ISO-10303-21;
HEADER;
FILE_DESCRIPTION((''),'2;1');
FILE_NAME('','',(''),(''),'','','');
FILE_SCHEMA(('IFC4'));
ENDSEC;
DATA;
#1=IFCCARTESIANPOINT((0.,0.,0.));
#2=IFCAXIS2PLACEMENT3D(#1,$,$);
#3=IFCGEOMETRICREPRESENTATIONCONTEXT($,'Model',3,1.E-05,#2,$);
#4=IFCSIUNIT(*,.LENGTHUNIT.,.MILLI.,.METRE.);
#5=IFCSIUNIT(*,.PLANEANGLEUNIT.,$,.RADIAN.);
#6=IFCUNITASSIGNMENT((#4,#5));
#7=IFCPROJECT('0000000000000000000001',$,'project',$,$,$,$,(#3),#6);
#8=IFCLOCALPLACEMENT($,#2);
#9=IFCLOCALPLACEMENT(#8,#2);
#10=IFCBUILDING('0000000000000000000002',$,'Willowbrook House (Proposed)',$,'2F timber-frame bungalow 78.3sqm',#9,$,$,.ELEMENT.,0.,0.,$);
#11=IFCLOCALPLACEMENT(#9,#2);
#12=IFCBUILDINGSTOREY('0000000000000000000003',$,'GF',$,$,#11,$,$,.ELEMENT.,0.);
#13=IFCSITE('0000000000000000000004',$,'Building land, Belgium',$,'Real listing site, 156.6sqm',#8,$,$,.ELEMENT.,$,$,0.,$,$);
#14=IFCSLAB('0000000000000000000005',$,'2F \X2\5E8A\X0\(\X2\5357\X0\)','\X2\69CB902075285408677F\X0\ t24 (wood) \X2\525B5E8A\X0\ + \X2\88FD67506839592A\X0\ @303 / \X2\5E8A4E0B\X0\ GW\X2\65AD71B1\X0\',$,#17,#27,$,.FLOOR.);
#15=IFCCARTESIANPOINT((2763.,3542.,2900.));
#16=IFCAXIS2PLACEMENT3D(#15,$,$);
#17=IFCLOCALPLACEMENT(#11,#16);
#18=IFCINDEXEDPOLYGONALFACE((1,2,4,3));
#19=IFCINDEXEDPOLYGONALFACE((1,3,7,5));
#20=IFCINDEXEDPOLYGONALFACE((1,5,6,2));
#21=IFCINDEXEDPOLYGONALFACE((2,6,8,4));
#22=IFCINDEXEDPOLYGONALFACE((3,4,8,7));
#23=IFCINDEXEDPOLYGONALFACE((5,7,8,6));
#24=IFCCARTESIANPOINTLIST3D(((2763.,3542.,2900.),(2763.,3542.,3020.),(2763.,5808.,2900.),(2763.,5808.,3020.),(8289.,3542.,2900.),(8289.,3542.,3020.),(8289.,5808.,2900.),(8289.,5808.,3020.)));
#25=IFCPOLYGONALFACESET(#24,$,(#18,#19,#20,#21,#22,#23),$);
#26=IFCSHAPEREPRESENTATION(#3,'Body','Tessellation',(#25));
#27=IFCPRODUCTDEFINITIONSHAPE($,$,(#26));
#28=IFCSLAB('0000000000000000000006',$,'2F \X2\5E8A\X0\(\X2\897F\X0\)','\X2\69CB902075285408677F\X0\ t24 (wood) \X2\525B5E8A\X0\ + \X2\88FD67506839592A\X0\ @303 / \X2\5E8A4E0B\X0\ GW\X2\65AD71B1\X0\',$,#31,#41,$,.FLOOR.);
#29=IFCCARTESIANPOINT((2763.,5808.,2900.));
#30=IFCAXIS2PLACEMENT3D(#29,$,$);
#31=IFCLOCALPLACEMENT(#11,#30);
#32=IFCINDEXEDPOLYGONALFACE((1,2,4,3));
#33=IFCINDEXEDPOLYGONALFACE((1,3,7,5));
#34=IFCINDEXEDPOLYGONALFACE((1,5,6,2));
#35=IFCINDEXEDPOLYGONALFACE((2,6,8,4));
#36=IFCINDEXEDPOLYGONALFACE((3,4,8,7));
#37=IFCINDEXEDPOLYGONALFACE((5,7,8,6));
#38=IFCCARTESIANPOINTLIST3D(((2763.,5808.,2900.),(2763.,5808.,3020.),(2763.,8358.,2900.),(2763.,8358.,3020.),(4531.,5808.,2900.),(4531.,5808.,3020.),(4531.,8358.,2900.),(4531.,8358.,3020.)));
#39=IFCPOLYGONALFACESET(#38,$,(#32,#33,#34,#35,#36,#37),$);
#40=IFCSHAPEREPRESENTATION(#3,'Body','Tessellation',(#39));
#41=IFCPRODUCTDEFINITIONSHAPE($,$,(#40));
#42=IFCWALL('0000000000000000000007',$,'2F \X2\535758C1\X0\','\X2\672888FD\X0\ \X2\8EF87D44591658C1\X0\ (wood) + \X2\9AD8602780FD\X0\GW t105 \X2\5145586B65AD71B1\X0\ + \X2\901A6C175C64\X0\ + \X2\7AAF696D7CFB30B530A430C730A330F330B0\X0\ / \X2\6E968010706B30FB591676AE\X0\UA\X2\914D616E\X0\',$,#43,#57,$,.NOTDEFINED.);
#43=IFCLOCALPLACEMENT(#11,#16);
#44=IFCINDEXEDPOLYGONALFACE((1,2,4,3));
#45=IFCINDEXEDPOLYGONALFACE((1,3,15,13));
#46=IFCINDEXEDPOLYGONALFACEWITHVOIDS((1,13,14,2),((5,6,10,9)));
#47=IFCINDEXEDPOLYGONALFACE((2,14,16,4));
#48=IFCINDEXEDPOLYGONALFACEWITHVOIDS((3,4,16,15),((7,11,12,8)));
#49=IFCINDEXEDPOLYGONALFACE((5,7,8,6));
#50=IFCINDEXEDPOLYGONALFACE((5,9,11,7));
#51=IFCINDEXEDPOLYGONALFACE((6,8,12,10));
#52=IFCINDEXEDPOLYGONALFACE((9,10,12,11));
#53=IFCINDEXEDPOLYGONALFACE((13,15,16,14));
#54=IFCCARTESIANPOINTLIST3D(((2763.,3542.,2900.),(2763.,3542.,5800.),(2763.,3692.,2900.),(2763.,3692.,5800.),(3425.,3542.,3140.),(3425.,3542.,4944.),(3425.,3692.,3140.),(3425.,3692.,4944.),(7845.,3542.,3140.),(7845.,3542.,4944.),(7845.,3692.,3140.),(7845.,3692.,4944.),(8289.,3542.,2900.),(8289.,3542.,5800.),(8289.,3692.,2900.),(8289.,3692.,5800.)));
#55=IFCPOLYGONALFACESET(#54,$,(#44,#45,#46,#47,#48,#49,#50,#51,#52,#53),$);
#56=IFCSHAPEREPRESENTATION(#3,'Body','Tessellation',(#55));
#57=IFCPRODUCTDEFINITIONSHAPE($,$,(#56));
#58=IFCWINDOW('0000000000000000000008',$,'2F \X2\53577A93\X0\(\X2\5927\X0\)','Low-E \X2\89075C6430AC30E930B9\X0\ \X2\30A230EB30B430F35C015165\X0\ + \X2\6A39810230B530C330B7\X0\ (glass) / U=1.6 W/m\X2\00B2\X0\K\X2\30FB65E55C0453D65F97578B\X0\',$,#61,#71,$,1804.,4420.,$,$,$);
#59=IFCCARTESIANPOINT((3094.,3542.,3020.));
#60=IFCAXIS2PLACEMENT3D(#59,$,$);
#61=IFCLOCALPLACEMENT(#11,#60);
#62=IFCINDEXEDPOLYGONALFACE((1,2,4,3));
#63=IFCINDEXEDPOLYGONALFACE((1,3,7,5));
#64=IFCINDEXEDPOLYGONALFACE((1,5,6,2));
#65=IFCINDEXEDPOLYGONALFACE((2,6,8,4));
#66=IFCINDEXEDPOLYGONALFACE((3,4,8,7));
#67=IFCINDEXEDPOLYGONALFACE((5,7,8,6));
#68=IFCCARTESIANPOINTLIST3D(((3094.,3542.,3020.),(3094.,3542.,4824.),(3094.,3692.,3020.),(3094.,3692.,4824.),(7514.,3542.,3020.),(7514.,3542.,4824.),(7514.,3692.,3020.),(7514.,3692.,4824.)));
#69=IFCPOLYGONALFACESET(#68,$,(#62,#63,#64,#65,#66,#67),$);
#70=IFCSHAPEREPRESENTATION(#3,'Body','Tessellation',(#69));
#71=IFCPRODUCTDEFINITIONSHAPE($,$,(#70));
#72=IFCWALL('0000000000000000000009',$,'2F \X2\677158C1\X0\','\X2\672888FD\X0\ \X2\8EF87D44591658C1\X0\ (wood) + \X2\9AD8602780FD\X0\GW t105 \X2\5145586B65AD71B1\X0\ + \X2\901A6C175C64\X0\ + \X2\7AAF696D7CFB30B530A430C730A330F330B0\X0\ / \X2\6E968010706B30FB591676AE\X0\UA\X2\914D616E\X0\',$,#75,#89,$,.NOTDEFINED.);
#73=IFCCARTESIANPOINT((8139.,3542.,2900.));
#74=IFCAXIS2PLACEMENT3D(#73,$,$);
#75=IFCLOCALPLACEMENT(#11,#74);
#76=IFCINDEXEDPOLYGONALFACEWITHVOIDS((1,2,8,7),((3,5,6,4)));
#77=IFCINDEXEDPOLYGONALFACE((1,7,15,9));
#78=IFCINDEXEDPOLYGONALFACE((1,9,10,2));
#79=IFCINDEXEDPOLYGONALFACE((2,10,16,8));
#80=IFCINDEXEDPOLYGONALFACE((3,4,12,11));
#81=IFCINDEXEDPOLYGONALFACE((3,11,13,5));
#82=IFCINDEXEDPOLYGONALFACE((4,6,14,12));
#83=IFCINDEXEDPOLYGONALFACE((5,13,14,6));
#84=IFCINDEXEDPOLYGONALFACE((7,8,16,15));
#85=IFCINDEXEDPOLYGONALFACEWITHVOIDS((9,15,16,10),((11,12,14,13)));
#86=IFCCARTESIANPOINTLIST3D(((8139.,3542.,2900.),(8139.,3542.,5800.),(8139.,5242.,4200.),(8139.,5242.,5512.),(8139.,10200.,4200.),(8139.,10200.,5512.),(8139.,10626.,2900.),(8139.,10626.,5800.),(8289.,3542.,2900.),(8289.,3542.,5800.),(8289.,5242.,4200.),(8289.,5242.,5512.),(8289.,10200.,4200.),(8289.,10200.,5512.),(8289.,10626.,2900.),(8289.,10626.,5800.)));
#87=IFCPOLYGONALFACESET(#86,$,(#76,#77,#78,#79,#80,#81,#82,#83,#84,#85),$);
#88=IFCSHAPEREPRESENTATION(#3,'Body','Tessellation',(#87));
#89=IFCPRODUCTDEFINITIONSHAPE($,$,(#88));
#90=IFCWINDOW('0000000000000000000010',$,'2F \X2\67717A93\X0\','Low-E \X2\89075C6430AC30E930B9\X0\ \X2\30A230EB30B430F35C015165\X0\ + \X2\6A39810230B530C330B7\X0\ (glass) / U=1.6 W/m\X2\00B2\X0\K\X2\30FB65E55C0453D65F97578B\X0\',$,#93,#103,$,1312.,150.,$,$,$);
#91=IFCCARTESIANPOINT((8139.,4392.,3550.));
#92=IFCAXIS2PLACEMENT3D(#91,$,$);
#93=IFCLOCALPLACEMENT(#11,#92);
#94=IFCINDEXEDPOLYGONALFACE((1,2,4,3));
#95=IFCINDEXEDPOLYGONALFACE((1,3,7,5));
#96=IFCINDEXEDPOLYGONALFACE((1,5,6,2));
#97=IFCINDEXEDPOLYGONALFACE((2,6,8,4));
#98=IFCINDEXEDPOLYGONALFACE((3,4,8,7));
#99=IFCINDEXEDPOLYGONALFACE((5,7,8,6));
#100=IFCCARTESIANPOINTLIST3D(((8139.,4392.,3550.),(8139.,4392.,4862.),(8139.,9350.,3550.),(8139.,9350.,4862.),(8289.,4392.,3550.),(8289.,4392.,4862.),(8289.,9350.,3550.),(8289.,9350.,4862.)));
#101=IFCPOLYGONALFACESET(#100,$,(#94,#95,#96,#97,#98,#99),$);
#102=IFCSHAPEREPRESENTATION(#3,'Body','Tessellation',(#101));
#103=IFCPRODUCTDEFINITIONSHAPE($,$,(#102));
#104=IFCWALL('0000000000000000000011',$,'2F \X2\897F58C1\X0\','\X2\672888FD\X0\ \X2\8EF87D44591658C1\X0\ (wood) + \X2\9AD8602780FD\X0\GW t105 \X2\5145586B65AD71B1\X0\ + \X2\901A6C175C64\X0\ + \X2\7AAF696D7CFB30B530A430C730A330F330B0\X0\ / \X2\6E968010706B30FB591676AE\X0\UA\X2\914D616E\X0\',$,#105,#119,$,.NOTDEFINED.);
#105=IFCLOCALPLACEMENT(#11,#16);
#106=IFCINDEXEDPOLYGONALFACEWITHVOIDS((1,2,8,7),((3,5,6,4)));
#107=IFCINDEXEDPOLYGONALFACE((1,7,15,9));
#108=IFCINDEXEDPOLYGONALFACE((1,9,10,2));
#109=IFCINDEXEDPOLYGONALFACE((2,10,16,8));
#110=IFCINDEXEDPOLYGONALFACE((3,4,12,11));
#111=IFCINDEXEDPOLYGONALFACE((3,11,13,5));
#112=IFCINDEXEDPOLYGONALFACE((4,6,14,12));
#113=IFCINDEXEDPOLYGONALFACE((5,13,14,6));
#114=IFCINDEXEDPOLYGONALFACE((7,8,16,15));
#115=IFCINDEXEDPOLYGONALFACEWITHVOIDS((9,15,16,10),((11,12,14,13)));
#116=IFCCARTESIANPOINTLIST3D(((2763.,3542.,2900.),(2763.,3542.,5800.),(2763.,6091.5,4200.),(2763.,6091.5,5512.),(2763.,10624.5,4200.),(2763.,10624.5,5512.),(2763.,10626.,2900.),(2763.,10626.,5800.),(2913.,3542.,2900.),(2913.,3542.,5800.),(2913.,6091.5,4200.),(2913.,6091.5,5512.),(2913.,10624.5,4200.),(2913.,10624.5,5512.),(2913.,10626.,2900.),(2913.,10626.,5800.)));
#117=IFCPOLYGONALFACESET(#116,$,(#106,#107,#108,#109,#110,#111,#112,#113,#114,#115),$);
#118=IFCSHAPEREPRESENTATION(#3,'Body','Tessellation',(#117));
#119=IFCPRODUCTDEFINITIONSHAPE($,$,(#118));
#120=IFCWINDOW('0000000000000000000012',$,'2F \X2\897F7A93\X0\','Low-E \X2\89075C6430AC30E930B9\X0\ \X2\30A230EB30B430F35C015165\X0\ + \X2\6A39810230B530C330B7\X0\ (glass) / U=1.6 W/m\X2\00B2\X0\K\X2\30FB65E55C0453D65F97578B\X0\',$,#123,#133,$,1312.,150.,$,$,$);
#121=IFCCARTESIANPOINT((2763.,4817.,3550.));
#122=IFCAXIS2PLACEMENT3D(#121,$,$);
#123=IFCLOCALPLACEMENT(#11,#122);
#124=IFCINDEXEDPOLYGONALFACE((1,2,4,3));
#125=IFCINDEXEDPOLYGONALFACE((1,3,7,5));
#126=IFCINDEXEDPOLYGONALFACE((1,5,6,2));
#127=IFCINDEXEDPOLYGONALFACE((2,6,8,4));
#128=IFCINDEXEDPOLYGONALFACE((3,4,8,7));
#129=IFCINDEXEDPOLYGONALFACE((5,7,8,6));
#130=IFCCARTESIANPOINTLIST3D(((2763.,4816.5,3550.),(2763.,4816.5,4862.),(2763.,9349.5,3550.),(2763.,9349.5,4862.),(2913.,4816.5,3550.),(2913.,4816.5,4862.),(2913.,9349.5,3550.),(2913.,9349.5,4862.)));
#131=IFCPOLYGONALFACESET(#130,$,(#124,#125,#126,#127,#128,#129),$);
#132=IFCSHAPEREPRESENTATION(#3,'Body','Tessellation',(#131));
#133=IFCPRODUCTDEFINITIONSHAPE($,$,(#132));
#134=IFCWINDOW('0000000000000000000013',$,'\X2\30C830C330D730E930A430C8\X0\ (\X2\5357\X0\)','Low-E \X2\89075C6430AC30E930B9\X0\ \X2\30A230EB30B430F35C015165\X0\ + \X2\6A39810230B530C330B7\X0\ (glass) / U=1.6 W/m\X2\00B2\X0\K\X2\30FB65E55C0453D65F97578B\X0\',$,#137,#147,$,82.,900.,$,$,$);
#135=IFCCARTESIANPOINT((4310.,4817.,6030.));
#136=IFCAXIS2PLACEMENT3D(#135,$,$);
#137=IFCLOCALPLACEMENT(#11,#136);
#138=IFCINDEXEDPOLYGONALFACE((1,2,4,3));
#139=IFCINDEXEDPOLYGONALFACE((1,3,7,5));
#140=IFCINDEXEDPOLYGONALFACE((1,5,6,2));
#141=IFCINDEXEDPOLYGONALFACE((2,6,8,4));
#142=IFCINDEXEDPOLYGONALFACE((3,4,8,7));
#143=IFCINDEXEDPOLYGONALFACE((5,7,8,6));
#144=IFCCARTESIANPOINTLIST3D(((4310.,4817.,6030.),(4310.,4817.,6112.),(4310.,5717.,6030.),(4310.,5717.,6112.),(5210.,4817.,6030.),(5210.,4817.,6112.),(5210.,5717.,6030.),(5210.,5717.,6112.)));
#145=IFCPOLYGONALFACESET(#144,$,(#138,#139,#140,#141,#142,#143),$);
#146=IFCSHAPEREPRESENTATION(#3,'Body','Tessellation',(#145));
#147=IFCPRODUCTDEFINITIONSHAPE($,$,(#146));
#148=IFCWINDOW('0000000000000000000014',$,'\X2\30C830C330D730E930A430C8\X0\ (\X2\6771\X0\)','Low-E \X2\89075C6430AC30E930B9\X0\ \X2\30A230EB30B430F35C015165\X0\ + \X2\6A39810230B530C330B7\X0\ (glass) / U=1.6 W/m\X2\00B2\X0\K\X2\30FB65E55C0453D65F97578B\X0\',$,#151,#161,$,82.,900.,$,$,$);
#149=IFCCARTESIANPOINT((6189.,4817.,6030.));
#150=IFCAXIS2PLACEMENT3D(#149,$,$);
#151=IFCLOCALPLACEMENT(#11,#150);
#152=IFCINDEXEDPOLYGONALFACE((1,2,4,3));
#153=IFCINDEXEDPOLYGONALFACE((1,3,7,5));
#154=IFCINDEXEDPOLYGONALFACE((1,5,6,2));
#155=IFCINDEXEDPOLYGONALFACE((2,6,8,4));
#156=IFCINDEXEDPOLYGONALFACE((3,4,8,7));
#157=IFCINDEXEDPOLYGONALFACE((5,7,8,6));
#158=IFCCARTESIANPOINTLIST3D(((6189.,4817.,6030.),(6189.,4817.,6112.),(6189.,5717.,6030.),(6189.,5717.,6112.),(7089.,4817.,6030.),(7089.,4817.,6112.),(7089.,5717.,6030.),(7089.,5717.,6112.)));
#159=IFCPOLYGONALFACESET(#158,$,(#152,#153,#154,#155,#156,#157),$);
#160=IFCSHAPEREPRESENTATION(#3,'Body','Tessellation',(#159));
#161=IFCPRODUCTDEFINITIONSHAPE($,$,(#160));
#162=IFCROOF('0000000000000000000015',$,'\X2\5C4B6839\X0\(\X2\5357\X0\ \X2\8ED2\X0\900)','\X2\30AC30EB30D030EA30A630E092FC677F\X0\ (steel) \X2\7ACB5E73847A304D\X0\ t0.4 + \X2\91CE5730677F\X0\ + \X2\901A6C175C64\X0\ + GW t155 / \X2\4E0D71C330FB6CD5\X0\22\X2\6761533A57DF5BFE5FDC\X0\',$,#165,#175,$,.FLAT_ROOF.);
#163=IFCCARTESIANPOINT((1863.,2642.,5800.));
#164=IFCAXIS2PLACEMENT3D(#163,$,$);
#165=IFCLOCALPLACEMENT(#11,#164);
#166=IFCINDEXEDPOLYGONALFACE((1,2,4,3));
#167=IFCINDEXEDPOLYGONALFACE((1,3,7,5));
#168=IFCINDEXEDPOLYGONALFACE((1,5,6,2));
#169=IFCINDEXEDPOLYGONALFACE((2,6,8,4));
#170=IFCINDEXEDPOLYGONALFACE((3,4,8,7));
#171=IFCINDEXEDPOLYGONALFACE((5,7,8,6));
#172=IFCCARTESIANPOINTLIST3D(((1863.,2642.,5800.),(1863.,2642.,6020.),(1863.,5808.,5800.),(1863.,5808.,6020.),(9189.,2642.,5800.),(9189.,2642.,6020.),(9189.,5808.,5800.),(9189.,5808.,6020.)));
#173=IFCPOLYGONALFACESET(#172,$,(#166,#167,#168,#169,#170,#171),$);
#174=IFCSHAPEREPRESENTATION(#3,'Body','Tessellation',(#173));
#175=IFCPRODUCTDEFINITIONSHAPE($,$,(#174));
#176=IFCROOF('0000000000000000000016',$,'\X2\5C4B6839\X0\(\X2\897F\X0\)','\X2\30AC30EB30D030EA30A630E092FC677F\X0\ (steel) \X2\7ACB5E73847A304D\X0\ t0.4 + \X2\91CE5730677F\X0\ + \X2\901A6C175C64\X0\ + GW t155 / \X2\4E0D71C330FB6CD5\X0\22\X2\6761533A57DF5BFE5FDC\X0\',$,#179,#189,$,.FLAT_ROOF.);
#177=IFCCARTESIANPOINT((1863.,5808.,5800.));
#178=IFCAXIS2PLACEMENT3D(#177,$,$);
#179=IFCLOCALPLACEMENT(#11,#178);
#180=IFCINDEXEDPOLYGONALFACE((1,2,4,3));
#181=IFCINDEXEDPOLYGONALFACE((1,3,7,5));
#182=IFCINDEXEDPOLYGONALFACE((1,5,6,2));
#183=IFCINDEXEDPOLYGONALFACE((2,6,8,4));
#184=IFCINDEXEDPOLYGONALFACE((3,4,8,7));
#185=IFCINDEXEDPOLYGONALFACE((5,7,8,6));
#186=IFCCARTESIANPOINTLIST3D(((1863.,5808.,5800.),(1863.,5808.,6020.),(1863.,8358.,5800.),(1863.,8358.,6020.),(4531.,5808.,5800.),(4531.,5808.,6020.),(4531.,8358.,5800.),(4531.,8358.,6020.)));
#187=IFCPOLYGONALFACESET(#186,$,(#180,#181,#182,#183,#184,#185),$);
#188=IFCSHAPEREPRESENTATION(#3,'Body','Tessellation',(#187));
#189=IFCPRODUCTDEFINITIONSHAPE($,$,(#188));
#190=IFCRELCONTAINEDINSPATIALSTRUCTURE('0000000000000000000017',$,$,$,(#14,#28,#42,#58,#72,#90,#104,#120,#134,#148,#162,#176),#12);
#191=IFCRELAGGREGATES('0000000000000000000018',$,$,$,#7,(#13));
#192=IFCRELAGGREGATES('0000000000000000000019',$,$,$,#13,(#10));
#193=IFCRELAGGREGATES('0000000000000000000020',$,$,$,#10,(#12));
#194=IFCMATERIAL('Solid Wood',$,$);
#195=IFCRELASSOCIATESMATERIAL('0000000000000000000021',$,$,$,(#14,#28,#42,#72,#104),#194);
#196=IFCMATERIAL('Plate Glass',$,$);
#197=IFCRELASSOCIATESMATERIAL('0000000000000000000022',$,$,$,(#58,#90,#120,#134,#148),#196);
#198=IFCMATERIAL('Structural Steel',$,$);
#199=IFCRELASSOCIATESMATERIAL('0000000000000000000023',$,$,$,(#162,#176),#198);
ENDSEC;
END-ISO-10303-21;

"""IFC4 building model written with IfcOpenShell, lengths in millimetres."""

from ifc_helpers import new_model, si_unit, frame, frame_2d, origin, place, context, project, spatial, rectangle, extrude, material, element, fill, save


model = new_model("IFC4")

# Units and contexts
model_context = context("Model", 3, precision=1e-05, world=origin())
ifc_project = project(units=[si_unit("LENGTHUNIT", "METRE", prefix="MILLI"), si_unit("PLANEANGLEUNIT", "RADIAN")], contexts=[model_context])

# Site, building, storey
site_placement = place(None, origin())
site = spatial("IfcSite", under=ifc_project, at=site_placement, Name="Building land, Belgium", ObjectType="Real listing site, 156.6sqm", CompositionType="ELEMENT", RefElevation=0.0)
building_placement = place(site_placement, origin())
building = spatial("IfcBuilding", under=site, at=building_placement, Name="Willowbrook House (Proposed)", ObjectType="2F timber-frame bungalow 78.3sqm", CompositionType="ELEMENT", ElevationOfRefHeight=0.0, ElevationOfTerrain=0.0)
storey_placement = place(building_placement, origin())
storey = spatial("IfcBuildingStorey", under=building, at=storey_placement, Name="GF", CompositionType="ELEMENT", Elevation=0.0)

# Slabs
ifc_material_1 = material(Name="Solid Wood")
slab_1_placement = place(storey_placement, frame((2763.0, 3542.0, 2900.0)))
element("IfcSlab", 1, at=slab_1_placement, inside=storey, material=ifc_material_1, Name="2F 床(南)", Description="構造用合板 t24 (wood) 剛床 + 製材根太 @303 / 床下 GW断熱", PredefinedType="FLOOR", context=model_context, shape_type="SweptSolid", body=[
    extrude(rectangle(XDim=5526.0, YDim=2266.0, at=frame_2d((2763.0, 1133.0))), frame((2763.0, 3542.0, 2900.0)), (0.0, 0.0, 1.0), 120.0),
])
slab_2_placement = place(storey_placement, frame((2763.0, 5808.0, 2900.0)))
element("IfcSlab", 2, at=slab_2_placement, inside=storey, material=ifc_material_1, Name="2F 床(西)", Description="構造用合板 t24 (wood) 剛床 + 製材根太 @303 / 床下 GW断熱", PredefinedType="FLOOR", context=model_context, shape_type="SweptSolid", body=[
    extrude(rectangle(XDim=1768.0, YDim=2550.0, at=frame_2d((884.0, 1275.0))), frame((2763.0, 5808.0, 2900.0)), (0.0, 0.0, 1.0), 120.0),
])

# Walls, openings, windows
wall_1_placement = place(storey_placement, frame((2763.0, 3542.0, 2900.0)))
wall_1 = element("IfcWall", 3, at=wall_1_placement, inside=storey, material=ifc_material_1, Name="2F 南壁", Description="木製 軸組外壁 (wood) + 高性能GW t105 充填断熱 + 通気層 + 窯業系サイディング / 準耐火・外皮UA配慮", PredefinedType="NOTDEFINED", context=model_context, shape_type="SweptSolid", body=[
    extrude(rectangle(XDim=5526.0, YDim=150.0, at=frame_2d((2763.0, 75.0))), frame((2763.0, 3542.0, 2900.0)), (0.0, 0.0, 1.0), 2900.0),
])
opening_1_placement = place(storey_placement, frame((3094.0, 3542.0, 3020.0)))
opening_1 = element("IfcOpeningElement", 4, at=opening_1_placement, cuts=wall_1, PredefinedType="NOTDEFINED", context=model_context, shape_type="SweptSolid", body=[
    extrude(rectangle(XDim=4420.0, YDim=150.0, at=frame_2d((2210.0, 75.0))), frame((3094.0, 3542.0, 3020.0)), (0.0, 0.0, 1.0), 1804.0),
])
ifc_material_2 = material(Name="Plate Glass")
window_1_placement = place(storey_placement, frame((3094.0, 3542.0, 3020.0)))
window_1 = element("IfcWindow", 5, at=window_1_placement, inside=storey, material=ifc_material_2, Name="2F 南窓(大)", Description="Low-E 複層ガラス アルゴン封入 + 樹脂サッシ (glass) / U=1.6 W/m²K・日射取得型", OverallHeight=1804.0, OverallWidth=4420.0, context=model_context, shape_type="SweptSolid", body=[
    extrude(rectangle(XDim=4420.0, YDim=150.0, at=frame_2d((2210.0, 75.0))), frame((3094.0, 3542.0, 3020.0)), (0.0, 0.0, 1.0), 1804.0),
])
fill(opening_1, window_1)
wall_2_placement = place(storey_placement, frame((8139.0, 3542.0, 2900.0)))
wall_2 = element("IfcWall", 6, at=wall_2_placement, inside=storey, material=ifc_material_1, Name="2F 東壁", Description="木製 軸組外壁 (wood) + 高性能GW t105 充填断熱 + 通気層 + 窯業系サイディング / 準耐火・外皮UA配慮", PredefinedType="NOTDEFINED", context=model_context, shape_type="SweptSolid", body=[
    extrude(rectangle(XDim=150.0, YDim=7084.0, at=frame_2d((75.0, 3542.0))), frame((8139.0, 3542.0, 2900.0)), (0.0, 0.0, 1.0), 2900.0),
])
opening_2_placement = place(storey_placement, frame((8139.0, 4392.0, 3550.0)))
opening_2 = element("IfcOpeningElement", 7, at=opening_2_placement, cuts=wall_2, PredefinedType="NOTDEFINED", context=model_context, shape_type="SweptSolid", body=[
    extrude(rectangle(XDim=150.0, YDim=4958.0, at=frame_2d((75.0, 2479.0))), frame((8139.0, 4392.0, 3550.0)), (0.0, 0.0, 1.0), 1312.0),
])
window_2_placement = place(storey_placement, frame((8139.0, 4392.0, 3550.0)))
window_2 = element("IfcWindow", 8, at=window_2_placement, inside=storey, material=ifc_material_2, Name="2F 東窓", Description="Low-E 複層ガラス アルゴン封入 + 樹脂サッシ (glass) / U=1.6 W/m²K・日射取得型", OverallHeight=1312.0, OverallWidth=150.0, context=model_context, shape_type="SweptSolid", body=[
    extrude(rectangle(XDim=150.0, YDim=4958.0, at=frame_2d((75.0, 2479.0))), frame((8139.0, 4392.0, 3550.0)), (0.0, 0.0, 1.0), 1312.0),
])
fill(opening_2, window_2)
wall_3_placement = place(storey_placement, frame((2763.0, 3542.0, 2900.0)))
wall_3 = element("IfcWall", 9, at=wall_3_placement, inside=storey, material=ifc_material_1, Name="2F 西壁", Description="木製 軸組外壁 (wood) + 高性能GW t105 充填断熱 + 通気層 + 窯業系サイディング / 準耐火・外皮UA配慮", PredefinedType="NOTDEFINED", context=model_context, shape_type="SweptSolid", body=[
    extrude(rectangle(XDim=150.0, YDim=7084.0, at=frame_2d((75.0, 3542.0))), frame((2763.0, 3542.0, 2900.0)), (0.0, 0.0, 1.0), 2900.0),
])
opening_3_placement = place(storey_placement, frame((2763.0, 4817.0, 3550.0)))
opening_3 = element("IfcOpeningElement", 10, at=opening_3_placement, cuts=wall_3, PredefinedType="NOTDEFINED", context=model_context, shape_type="SweptSolid", body=[
    extrude(rectangle(XDim=150.0, YDim=4533.0, at=frame_2d((75.0, 2266.0))), frame((2763.0, 4817.0, 3550.0)), (0.0, 0.0, 1.0), 1312.0),
])
window_3_placement = place(storey_placement, frame((2763.0, 4817.0, 3550.0)))
window_3 = element("IfcWindow", 11, at=window_3_placement, inside=storey, material=ifc_material_2, Name="2F 西窓", Description="Low-E 複層ガラス アルゴン封入 + 樹脂サッシ (glass) / U=1.6 W/m²K・日射取得型", OverallHeight=1312.0, OverallWidth=150.0, context=model_context, shape_type="SweptSolid", body=[
    extrude(rectangle(XDim=150.0, YDim=4533.0, at=frame_2d((75.0, 2266.0))), frame((2763.0, 4817.0, 3550.0)), (0.0, 0.0, 1.0), 1312.0),
])
fill(opening_3, window_3)

# Windows
window_4_placement = place(storey_placement, frame((4310.0, 4817.0, 6030.0)))
element("IfcWindow", 12, at=window_4_placement, inside=storey, material=ifc_material_2, Name="トップライト (南)", Description="Low-E 複層ガラス アルゴン封入 + 樹脂サッシ (glass) / U=1.6 W/m²K・日射取得型", OverallHeight=82.0, OverallWidth=900.0, context=model_context, shape_type="SweptSolid", body=[
    extrude(rectangle(XDim=900.0, YDim=900.0, at=frame_2d((450.0, 450.0))), frame((4310.0, 4817.0, 6030.0)), (0.0, 0.0, 1.0), 82.0),
])
window_5_placement = place(storey_placement, frame((6189.0, 4817.0, 6030.0)))
element("IfcWindow", 13, at=window_5_placement, inside=storey, material=ifc_material_2, Name="トップライト (東)", Description="Low-E 複層ガラス アルゴン封入 + 樹脂サッシ (glass) / U=1.6 W/m²K・日射取得型", OverallHeight=82.0, OverallWidth=900.0, context=model_context, shape_type="SweptSolid", body=[
    extrude(rectangle(XDim=900.0, YDim=900.0, at=frame_2d((450.0, 450.0))), frame((6189.0, 4817.0, 6030.0)), (0.0, 0.0, 1.0), 82.0),
])

# Roofs
ifc_material_3 = material(Name="Structural Steel")
roof_1_placement = place(storey_placement, frame((1863.0, 2642.0, 5800.0)))
element("IfcRoof", 14, at=roof_1_placement, inside=storey, material=ifc_material_3, Name="屋根(南 軒900)", Description="ガルバリウム鋼板 (steel) 立平葺き t0.4 + 野地板 + 通気層 + GW t155 / 不燃・法22条区域対応", PredefinedType="FLAT_ROOF", context=model_context, shape_type="SweptSolid", body=[
    extrude(rectangle(XDim=7326.0, YDim=3166.0, at=frame_2d((3663.0, 1583.0))), frame((1863.0, 2642.0, 5800.0)), (0.0, 0.0, 1.0), 220.0),
])
roof_2_placement = place(storey_placement, frame((1863.0, 5808.0, 5800.0)))
element("IfcRoof", 15, at=roof_2_placement, inside=storey, material=ifc_material_3, Name="屋根(西)", Description="ガルバリウム鋼板 (steel) 立平葺き t0.4 + 野地板 + 通気層 + GW t155 / 不燃・法22条区域対応", PredefinedType="FLAT_ROOF", context=model_context, shape_type="SweptSolid", body=[
    extrude(rectangle(XDim=2668.0, YDim=2550.0, at=frame_2d((1334.0, 1275.0))), frame((1863.0, 5808.0, 5800.0)), (0.0, 0.0, 1.0), 220.0),
])

save(model, "model.ifc")
